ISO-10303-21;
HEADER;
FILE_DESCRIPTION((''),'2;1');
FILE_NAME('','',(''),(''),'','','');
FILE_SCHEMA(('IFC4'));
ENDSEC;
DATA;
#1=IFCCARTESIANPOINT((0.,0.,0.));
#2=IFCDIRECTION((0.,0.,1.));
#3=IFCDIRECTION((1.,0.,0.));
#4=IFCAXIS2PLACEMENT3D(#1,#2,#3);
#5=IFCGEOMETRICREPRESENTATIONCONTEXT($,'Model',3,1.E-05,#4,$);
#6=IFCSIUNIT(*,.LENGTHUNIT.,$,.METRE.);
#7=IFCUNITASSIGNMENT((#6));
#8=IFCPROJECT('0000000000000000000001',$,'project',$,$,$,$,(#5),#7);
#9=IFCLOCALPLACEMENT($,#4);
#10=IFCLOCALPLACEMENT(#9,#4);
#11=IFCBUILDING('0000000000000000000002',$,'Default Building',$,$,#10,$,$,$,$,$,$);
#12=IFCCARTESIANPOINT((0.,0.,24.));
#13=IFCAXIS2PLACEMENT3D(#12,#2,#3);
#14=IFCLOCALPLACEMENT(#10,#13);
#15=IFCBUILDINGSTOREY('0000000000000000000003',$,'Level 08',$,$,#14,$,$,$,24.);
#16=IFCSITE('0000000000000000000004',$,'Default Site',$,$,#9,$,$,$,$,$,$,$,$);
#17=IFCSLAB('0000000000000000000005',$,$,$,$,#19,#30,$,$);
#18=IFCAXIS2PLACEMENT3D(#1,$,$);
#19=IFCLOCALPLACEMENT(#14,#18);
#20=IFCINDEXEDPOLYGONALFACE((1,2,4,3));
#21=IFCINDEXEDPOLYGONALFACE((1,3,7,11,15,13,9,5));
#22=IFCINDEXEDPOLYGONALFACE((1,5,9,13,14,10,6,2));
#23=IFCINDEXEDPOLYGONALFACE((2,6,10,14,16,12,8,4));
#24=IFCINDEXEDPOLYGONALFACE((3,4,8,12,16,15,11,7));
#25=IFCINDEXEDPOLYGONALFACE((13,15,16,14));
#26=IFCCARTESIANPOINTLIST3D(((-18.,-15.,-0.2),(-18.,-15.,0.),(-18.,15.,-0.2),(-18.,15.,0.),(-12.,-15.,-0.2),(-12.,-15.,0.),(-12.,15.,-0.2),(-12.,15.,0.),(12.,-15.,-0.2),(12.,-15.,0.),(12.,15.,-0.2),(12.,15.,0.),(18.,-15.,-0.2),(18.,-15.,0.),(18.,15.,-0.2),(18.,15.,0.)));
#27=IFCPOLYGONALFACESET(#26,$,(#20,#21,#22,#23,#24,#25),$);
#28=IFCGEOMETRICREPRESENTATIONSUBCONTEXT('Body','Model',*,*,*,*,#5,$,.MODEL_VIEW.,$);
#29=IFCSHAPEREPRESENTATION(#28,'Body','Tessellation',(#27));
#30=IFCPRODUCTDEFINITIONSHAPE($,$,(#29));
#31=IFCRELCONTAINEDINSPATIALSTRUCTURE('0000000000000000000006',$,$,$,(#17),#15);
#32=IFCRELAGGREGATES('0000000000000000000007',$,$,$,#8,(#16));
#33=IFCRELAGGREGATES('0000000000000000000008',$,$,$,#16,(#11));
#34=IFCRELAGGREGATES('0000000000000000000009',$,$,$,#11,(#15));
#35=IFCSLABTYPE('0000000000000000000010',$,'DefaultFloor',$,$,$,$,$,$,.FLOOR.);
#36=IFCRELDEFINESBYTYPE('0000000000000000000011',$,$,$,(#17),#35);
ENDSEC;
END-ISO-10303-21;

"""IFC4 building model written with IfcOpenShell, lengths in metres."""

from ifc_helpers import new_model, si_unit, frame, origin_with_axes, place, context, subcontext, project, spatial, polyline, outline, extrude, type_object, element, save


model = new_model("IFC4")

# Units and contexts
model_context = context("Model", 3, precision=1e-05, world=origin_with_axes())
body_context = subcontext(model_context, "Body", "Model", "MODEL_VIEW")
ifc_project = project(units=[si_unit("LENGTHUNIT", "METRE")], contexts=[model_context])

# Site, building, storey
site_placement = place(None, origin_with_axes())
site = spatial("IfcSite", under=ifc_project, at=site_placement, Name="Default Site")
building_placement = place(site_placement, origin_with_axes())
building = spatial("IfcBuilding", under=site, at=building_placement, Name="Default Building")
storey_placement = place(building_placement, frame((0.0, 0.0, 24.0), z_axis=(0.0, 0.0, 1.0), x_axis=(1.0, 0.0, 0.0)))
storey = spatial("IfcBuildingStorey", under=building, at=storey_placement, Name="Level 08", Elevation=24.0)

# Slab
slab_type = type_object("IfcSlabType", Name="DefaultFloor", PredefinedType="FLOOR")
slab_placement = place(storey_placement, frame((0.0, 0.0, -24.0), z_axis=(0.0, 0.0, 1.0), x_axis=(1.0, 0.0, 0.0)))
element("IfcSlab", 1, at=slab_placement, inside=storey, type_object=slab_type, context=body_context, shape_type="SweptSolid", body=[
    extrude(outline(polyline([(-18.0, 15.0), (-12.0, 15.0), (12.0, 15.0), (18.0, 15.0), (18.0, -15.0), (12.0, -15.0), (-12.0, -15.0), (-18.0, -15.0), (-18.0, 15.0)])), frame((0.0, 0.0, 24.0), z_axis=(0.0, 0.0, 1.0), x_axis=(1.0, 0.0, 0.0)), (0.0, 0.0, -1.0), 0.2),
])

save(model, "model.ifc")
